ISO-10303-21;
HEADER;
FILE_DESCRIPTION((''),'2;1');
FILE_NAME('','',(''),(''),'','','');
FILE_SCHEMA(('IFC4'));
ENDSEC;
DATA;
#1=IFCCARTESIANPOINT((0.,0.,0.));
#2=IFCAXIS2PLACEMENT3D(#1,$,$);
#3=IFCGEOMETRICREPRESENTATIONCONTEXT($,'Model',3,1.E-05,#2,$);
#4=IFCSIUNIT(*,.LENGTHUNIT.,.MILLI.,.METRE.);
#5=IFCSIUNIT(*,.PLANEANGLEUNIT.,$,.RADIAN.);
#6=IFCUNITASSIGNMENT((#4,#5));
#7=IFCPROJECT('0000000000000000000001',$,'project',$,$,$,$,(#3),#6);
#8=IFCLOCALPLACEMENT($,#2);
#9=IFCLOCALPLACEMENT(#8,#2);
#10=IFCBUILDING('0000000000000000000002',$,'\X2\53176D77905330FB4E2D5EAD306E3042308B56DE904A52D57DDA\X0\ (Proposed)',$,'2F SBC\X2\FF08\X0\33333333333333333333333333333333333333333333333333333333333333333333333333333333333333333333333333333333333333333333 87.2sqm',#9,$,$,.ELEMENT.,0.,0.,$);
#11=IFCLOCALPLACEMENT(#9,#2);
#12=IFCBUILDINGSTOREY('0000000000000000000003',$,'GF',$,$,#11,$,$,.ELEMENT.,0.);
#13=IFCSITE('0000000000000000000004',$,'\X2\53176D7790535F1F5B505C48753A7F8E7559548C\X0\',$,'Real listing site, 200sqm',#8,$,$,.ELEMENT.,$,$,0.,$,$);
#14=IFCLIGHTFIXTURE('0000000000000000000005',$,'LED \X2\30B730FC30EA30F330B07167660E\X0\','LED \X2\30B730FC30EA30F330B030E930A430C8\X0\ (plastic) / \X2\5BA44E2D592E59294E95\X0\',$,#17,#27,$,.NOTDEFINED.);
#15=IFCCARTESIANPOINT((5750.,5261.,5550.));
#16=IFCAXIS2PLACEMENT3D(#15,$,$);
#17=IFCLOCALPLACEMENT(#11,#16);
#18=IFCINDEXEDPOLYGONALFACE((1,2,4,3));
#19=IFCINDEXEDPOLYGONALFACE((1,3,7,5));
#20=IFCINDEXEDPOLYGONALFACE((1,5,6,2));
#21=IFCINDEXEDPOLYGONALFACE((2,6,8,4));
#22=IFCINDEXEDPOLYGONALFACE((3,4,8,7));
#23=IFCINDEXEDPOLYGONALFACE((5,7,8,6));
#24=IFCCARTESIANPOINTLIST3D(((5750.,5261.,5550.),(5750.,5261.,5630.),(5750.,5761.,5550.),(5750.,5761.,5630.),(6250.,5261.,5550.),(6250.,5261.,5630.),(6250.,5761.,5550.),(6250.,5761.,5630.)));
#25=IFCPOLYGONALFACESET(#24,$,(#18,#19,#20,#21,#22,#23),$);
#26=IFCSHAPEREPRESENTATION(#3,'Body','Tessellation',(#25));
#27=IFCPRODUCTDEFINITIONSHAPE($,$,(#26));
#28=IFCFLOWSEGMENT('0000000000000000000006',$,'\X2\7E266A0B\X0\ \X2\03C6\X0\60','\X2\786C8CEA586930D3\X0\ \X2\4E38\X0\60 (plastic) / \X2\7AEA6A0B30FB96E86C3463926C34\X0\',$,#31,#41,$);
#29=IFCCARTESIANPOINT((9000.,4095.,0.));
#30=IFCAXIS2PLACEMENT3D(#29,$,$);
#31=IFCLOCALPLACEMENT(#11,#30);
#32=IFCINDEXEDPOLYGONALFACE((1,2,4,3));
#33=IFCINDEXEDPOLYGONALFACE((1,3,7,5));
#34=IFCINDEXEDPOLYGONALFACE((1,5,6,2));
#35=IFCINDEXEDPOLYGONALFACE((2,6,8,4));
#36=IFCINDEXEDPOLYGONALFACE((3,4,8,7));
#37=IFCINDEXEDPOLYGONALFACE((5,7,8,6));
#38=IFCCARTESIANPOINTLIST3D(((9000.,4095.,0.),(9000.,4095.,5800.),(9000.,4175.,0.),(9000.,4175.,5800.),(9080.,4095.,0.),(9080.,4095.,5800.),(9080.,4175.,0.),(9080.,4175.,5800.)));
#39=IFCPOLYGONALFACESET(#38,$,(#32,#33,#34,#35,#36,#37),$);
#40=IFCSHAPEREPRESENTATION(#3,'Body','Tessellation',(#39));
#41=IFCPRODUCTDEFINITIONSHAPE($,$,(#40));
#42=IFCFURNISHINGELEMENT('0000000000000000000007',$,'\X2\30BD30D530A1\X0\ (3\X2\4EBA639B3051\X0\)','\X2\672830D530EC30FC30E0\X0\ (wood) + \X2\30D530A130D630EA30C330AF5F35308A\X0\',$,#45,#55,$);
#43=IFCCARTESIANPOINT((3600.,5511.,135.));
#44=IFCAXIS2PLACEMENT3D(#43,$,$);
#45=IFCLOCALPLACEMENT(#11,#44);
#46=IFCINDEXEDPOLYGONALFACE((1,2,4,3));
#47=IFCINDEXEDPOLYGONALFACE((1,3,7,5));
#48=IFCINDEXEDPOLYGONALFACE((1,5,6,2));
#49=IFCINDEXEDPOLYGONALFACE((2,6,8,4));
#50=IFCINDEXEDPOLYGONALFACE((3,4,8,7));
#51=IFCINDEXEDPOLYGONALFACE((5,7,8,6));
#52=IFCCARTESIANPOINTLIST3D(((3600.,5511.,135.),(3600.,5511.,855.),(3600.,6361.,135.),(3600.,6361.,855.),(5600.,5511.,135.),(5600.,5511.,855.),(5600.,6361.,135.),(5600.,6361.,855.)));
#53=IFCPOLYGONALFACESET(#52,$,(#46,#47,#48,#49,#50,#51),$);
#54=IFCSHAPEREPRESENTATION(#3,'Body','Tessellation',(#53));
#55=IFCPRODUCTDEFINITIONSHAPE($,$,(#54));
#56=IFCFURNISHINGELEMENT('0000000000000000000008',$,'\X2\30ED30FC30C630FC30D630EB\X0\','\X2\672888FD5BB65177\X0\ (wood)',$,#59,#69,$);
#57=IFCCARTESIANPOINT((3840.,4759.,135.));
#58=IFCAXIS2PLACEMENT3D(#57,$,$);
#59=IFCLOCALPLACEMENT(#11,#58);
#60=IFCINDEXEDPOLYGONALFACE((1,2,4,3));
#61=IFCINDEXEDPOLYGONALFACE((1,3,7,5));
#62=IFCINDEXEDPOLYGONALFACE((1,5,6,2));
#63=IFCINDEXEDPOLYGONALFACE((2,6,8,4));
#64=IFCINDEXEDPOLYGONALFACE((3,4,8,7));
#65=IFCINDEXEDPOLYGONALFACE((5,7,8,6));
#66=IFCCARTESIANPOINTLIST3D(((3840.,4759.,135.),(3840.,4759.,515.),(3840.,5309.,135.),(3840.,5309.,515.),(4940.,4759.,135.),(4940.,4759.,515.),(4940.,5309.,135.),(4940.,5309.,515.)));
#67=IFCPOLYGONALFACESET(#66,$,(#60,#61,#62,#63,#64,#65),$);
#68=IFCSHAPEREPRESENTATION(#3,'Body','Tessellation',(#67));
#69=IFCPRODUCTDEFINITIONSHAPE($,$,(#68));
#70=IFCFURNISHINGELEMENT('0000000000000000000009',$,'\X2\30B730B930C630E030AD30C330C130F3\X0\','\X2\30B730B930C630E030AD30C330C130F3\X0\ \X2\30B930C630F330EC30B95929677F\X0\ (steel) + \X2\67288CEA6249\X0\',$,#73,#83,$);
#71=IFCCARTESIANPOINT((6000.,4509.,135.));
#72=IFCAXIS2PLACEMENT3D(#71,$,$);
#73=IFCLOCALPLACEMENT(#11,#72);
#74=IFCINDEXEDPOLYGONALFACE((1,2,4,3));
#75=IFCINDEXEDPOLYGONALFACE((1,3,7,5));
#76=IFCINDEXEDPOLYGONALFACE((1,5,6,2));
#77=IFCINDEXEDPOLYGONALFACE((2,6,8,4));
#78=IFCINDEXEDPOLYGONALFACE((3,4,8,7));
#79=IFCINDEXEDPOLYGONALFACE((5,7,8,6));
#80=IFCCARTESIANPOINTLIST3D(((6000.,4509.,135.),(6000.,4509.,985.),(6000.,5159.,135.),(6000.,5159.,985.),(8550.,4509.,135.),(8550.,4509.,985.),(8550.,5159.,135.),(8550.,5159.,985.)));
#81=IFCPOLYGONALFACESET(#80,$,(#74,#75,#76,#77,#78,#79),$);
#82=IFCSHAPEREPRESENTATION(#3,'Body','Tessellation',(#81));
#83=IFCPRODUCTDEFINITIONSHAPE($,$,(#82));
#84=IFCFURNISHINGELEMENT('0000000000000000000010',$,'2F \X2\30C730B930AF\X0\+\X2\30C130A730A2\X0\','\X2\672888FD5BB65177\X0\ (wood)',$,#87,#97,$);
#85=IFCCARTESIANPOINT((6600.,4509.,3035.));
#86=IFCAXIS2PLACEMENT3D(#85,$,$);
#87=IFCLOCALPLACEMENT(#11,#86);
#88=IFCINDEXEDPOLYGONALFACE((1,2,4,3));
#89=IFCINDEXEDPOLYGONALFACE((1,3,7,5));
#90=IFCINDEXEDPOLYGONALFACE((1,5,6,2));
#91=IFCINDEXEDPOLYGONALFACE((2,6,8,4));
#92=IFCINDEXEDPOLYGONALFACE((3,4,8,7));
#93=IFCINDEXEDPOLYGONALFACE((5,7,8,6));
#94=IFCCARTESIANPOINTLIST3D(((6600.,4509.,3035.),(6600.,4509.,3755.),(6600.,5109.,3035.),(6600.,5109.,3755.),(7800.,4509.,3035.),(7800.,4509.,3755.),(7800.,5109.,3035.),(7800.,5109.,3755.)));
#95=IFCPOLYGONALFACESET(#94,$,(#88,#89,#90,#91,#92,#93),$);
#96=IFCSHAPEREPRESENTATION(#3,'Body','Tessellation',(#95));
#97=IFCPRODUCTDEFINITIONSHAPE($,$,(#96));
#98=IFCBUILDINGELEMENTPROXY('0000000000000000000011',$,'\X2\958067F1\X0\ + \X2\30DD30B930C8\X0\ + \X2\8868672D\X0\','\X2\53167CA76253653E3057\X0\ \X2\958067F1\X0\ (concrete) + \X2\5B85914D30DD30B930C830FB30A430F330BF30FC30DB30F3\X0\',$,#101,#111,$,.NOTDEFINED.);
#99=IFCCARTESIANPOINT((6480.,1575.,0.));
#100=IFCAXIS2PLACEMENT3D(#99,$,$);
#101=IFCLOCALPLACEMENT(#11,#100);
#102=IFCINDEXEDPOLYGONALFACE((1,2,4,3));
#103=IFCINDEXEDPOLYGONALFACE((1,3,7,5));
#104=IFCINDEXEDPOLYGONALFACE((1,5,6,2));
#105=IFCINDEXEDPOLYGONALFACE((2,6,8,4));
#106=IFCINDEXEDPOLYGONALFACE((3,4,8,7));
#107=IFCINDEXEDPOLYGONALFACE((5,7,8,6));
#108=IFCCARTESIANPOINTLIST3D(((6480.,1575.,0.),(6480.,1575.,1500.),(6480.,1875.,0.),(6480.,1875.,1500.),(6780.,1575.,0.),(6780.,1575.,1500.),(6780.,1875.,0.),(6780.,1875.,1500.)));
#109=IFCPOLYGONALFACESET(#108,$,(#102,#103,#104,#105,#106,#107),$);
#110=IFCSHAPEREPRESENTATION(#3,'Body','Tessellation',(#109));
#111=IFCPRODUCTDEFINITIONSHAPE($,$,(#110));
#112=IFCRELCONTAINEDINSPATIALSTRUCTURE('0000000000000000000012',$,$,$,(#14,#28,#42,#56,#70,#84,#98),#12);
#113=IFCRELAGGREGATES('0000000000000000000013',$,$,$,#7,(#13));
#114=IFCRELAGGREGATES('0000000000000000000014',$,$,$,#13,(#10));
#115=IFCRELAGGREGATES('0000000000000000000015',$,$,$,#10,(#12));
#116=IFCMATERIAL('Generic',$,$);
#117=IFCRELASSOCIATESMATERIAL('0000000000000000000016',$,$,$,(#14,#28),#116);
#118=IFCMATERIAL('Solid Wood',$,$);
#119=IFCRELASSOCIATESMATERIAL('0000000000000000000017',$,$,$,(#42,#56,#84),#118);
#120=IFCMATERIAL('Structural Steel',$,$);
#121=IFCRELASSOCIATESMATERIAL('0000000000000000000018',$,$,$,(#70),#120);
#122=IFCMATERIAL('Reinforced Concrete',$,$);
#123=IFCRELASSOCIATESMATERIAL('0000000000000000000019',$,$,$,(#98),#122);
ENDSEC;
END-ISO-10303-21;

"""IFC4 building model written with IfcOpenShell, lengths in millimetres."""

from ifc_helpers import new_model, si_unit, frame, frame_2d, origin, place, context, project, spatial, rectangle, extrude, material, element, save


model = new_model("IFC4")

# Units and contexts
model_context = context("Model", 3, precision=1e-05, world=origin())
ifc_project = project(units=[si_unit("LENGTHUNIT", "METRE", prefix="MILLI"), si_unit("PLANEANGLEUNIT", "RADIAN")], contexts=[model_context])

# Site, building, storey
site_placement = place(None, origin())
site = spatial("IfcSite", under=ifc_project, at=site_placement, Name="北海道弟子屈町美留和", ObjectType="Real listing site, 200sqm", CompositionType="ELEMENT", RefElevation=0.0)
building_placement = place(site_placement, origin())
building = spatial("IfcBuilding", under=site, at=building_placement, Name="北海道・中庭のある回遊動線 (Proposed)", ObjectType="2F SBC（33333333333333333333333333333333333333333333333333333333333333333333333333333333333333333333333333333333333333333333 87.2sqm", CompositionType="ELEMENT", ElevationOfRefHeight=0.0, ElevationOfTerrain=0.0)
storey_placement = place(building_placement, origin())
storey = spatial("IfcBuildingStorey", under=building, at=storey_placement, Name="GF", CompositionType="ELEMENT", Elevation=0.0)

# Shared definitions
ifc_material_1 = material(Name="Solid Wood")

# Shared definitions
ifc_material_2 = material(Name="Reinforced Concrete")

# Shared definitions
ifc_material_3 = material(Name="Structural Steel")

# Shared definitions
ifc_material_4 = material(Name="Generic")

# Light fixture
light_fixture_1_placement = place(storey_placement, frame((5750.0, 5261.0, 5550.0)))
element("IfcLightFixture", 1, at=light_fixture_1_placement, inside=storey, material=ifc_material_4, Name="LED シーリング照明", Description="LED シーリングライト (plastic) / 室中央天井", PredefinedType="NOTDEFINED", context=model_context, shape_type="SweptSolid", body=[
    extrude(rectangle(XDim=500.0, YDim=500.0, at=frame_2d((250.0, 250.0))), frame((5750.0, 5261.0, 5550.0)), (0.0, 0.0, 1.0), 80.0),
])

# Flow segment
flow_segment_placement = place(storey_placement, frame((9000.0, 4095.0, 0.0)))
element("IfcFlowSegment", 2, at=flow_segment_placement, inside=storey, material=ifc_material_4, Name="縦樋 φ60", Description="硬質塩ビ 丸60 (plastic) / 竪樋・雨水排水", context=model_context, shape_type="SweptSolid", body=[
    extrude(rectangle(XDim=80.0, YDim=80.0, at=frame_2d((40.0, 40.0))), frame((9000.0, 4095.0, 0.0)), (0.0, 0.0, 1.0), 5800.0),
])

# Furnishing elements
furnishing_1_placement = place(storey_placement, frame((3600.0, 5511.0, 135.0)))
element("IfcFurnishingElement", 3, at=furnishing_1_placement, inside=storey, material=ifc_material_1, Name="ソファ (3人掛け)", Description="木フレーム (wood) + ファブリック張り", context=model_context, shape_type="SweptSolid", body=[
    extrude(rectangle(XDim=2000.0, YDim=850.0, at=frame_2d((1000.0, 425.0))), frame((3600.0, 5511.0, 135.0)), (0.0, 0.0, 1.0), 720.0),
])
furnishing_2_placement = place(storey_placement, frame((3840.0, 4759.0, 135.0)))
element("IfcFurnishingElement", 4, at=furnishing_2_placement, inside=storey, material=ifc_material_1, Name="ローテーブル", Description="木製家具 (wood)", context=model_context, shape_type="SweptSolid", body=[
    extrude(rectangle(XDim=1100.0, YDim=550.0, at=frame_2d((550.0, 275.0))), frame((3840.0, 4759.0, 135.0)), (0.0, 0.0, 1.0), 380.0),
])
furnishing_3_placement = place(storey_placement, frame((6000.0, 4509.0, 135.0)))
element("IfcFurnishingElement", 5, at=furnishing_3_placement, inside=storey, material=ifc_material_3, Name="システムキッチン", Description="システムキッチン ステンレス天板 (steel) + 木質扉", context=model_context, shape_type="SweptSolid", body=[
    extrude(rectangle(XDim=2550.0, YDim=650.0, at=frame_2d((1275.0, 325.0))), frame((6000.0, 4509.0, 135.0)), (0.0, 0.0, 1.0), 850.0),
])
furnishing_4_placement = place(storey_placement, frame((6600.0, 4509.0, 3035.0)))
element("IfcFurnishingElement", 6, at=furnishing_4_placement, inside=storey, material=ifc_material_1, Name="2F デスク+チェア", Description="木製家具 (wood)", context=model_context, shape_type="SweptSolid", body=[
    extrude(rectangle(XDim=1200.0, YDim=600.0, at=frame_2d((600.0, 300.0))), frame((6600.0, 4509.0, 3035.0)), (0.0, 0.0, 1.0), 720.0),
])

# Building element proxy
proxy_placement = place(storey_placement, frame((6480.0, 1575.0, 0.0)))
element("IfcBuildingElementProxy", 7, at=proxy_placement, inside=storey, material=ifc_material_2, Name="門柱 + ポスト + 表札", Description="化粧打放し 門柱 (concrete) + 宅配ポスト・インターホン", PredefinedType="NOTDEFINED", context=model_context, shape_type="SweptSolid", body=[
    extrude(rectangle(XDim=300.0, YDim=300.0, at=frame_2d((150.0, 150.0))), frame((6480.0, 1575.0, 0.0)), (0.0, 0.0, 1.0), 1500.0),
])

save(model, "model.ifc")
